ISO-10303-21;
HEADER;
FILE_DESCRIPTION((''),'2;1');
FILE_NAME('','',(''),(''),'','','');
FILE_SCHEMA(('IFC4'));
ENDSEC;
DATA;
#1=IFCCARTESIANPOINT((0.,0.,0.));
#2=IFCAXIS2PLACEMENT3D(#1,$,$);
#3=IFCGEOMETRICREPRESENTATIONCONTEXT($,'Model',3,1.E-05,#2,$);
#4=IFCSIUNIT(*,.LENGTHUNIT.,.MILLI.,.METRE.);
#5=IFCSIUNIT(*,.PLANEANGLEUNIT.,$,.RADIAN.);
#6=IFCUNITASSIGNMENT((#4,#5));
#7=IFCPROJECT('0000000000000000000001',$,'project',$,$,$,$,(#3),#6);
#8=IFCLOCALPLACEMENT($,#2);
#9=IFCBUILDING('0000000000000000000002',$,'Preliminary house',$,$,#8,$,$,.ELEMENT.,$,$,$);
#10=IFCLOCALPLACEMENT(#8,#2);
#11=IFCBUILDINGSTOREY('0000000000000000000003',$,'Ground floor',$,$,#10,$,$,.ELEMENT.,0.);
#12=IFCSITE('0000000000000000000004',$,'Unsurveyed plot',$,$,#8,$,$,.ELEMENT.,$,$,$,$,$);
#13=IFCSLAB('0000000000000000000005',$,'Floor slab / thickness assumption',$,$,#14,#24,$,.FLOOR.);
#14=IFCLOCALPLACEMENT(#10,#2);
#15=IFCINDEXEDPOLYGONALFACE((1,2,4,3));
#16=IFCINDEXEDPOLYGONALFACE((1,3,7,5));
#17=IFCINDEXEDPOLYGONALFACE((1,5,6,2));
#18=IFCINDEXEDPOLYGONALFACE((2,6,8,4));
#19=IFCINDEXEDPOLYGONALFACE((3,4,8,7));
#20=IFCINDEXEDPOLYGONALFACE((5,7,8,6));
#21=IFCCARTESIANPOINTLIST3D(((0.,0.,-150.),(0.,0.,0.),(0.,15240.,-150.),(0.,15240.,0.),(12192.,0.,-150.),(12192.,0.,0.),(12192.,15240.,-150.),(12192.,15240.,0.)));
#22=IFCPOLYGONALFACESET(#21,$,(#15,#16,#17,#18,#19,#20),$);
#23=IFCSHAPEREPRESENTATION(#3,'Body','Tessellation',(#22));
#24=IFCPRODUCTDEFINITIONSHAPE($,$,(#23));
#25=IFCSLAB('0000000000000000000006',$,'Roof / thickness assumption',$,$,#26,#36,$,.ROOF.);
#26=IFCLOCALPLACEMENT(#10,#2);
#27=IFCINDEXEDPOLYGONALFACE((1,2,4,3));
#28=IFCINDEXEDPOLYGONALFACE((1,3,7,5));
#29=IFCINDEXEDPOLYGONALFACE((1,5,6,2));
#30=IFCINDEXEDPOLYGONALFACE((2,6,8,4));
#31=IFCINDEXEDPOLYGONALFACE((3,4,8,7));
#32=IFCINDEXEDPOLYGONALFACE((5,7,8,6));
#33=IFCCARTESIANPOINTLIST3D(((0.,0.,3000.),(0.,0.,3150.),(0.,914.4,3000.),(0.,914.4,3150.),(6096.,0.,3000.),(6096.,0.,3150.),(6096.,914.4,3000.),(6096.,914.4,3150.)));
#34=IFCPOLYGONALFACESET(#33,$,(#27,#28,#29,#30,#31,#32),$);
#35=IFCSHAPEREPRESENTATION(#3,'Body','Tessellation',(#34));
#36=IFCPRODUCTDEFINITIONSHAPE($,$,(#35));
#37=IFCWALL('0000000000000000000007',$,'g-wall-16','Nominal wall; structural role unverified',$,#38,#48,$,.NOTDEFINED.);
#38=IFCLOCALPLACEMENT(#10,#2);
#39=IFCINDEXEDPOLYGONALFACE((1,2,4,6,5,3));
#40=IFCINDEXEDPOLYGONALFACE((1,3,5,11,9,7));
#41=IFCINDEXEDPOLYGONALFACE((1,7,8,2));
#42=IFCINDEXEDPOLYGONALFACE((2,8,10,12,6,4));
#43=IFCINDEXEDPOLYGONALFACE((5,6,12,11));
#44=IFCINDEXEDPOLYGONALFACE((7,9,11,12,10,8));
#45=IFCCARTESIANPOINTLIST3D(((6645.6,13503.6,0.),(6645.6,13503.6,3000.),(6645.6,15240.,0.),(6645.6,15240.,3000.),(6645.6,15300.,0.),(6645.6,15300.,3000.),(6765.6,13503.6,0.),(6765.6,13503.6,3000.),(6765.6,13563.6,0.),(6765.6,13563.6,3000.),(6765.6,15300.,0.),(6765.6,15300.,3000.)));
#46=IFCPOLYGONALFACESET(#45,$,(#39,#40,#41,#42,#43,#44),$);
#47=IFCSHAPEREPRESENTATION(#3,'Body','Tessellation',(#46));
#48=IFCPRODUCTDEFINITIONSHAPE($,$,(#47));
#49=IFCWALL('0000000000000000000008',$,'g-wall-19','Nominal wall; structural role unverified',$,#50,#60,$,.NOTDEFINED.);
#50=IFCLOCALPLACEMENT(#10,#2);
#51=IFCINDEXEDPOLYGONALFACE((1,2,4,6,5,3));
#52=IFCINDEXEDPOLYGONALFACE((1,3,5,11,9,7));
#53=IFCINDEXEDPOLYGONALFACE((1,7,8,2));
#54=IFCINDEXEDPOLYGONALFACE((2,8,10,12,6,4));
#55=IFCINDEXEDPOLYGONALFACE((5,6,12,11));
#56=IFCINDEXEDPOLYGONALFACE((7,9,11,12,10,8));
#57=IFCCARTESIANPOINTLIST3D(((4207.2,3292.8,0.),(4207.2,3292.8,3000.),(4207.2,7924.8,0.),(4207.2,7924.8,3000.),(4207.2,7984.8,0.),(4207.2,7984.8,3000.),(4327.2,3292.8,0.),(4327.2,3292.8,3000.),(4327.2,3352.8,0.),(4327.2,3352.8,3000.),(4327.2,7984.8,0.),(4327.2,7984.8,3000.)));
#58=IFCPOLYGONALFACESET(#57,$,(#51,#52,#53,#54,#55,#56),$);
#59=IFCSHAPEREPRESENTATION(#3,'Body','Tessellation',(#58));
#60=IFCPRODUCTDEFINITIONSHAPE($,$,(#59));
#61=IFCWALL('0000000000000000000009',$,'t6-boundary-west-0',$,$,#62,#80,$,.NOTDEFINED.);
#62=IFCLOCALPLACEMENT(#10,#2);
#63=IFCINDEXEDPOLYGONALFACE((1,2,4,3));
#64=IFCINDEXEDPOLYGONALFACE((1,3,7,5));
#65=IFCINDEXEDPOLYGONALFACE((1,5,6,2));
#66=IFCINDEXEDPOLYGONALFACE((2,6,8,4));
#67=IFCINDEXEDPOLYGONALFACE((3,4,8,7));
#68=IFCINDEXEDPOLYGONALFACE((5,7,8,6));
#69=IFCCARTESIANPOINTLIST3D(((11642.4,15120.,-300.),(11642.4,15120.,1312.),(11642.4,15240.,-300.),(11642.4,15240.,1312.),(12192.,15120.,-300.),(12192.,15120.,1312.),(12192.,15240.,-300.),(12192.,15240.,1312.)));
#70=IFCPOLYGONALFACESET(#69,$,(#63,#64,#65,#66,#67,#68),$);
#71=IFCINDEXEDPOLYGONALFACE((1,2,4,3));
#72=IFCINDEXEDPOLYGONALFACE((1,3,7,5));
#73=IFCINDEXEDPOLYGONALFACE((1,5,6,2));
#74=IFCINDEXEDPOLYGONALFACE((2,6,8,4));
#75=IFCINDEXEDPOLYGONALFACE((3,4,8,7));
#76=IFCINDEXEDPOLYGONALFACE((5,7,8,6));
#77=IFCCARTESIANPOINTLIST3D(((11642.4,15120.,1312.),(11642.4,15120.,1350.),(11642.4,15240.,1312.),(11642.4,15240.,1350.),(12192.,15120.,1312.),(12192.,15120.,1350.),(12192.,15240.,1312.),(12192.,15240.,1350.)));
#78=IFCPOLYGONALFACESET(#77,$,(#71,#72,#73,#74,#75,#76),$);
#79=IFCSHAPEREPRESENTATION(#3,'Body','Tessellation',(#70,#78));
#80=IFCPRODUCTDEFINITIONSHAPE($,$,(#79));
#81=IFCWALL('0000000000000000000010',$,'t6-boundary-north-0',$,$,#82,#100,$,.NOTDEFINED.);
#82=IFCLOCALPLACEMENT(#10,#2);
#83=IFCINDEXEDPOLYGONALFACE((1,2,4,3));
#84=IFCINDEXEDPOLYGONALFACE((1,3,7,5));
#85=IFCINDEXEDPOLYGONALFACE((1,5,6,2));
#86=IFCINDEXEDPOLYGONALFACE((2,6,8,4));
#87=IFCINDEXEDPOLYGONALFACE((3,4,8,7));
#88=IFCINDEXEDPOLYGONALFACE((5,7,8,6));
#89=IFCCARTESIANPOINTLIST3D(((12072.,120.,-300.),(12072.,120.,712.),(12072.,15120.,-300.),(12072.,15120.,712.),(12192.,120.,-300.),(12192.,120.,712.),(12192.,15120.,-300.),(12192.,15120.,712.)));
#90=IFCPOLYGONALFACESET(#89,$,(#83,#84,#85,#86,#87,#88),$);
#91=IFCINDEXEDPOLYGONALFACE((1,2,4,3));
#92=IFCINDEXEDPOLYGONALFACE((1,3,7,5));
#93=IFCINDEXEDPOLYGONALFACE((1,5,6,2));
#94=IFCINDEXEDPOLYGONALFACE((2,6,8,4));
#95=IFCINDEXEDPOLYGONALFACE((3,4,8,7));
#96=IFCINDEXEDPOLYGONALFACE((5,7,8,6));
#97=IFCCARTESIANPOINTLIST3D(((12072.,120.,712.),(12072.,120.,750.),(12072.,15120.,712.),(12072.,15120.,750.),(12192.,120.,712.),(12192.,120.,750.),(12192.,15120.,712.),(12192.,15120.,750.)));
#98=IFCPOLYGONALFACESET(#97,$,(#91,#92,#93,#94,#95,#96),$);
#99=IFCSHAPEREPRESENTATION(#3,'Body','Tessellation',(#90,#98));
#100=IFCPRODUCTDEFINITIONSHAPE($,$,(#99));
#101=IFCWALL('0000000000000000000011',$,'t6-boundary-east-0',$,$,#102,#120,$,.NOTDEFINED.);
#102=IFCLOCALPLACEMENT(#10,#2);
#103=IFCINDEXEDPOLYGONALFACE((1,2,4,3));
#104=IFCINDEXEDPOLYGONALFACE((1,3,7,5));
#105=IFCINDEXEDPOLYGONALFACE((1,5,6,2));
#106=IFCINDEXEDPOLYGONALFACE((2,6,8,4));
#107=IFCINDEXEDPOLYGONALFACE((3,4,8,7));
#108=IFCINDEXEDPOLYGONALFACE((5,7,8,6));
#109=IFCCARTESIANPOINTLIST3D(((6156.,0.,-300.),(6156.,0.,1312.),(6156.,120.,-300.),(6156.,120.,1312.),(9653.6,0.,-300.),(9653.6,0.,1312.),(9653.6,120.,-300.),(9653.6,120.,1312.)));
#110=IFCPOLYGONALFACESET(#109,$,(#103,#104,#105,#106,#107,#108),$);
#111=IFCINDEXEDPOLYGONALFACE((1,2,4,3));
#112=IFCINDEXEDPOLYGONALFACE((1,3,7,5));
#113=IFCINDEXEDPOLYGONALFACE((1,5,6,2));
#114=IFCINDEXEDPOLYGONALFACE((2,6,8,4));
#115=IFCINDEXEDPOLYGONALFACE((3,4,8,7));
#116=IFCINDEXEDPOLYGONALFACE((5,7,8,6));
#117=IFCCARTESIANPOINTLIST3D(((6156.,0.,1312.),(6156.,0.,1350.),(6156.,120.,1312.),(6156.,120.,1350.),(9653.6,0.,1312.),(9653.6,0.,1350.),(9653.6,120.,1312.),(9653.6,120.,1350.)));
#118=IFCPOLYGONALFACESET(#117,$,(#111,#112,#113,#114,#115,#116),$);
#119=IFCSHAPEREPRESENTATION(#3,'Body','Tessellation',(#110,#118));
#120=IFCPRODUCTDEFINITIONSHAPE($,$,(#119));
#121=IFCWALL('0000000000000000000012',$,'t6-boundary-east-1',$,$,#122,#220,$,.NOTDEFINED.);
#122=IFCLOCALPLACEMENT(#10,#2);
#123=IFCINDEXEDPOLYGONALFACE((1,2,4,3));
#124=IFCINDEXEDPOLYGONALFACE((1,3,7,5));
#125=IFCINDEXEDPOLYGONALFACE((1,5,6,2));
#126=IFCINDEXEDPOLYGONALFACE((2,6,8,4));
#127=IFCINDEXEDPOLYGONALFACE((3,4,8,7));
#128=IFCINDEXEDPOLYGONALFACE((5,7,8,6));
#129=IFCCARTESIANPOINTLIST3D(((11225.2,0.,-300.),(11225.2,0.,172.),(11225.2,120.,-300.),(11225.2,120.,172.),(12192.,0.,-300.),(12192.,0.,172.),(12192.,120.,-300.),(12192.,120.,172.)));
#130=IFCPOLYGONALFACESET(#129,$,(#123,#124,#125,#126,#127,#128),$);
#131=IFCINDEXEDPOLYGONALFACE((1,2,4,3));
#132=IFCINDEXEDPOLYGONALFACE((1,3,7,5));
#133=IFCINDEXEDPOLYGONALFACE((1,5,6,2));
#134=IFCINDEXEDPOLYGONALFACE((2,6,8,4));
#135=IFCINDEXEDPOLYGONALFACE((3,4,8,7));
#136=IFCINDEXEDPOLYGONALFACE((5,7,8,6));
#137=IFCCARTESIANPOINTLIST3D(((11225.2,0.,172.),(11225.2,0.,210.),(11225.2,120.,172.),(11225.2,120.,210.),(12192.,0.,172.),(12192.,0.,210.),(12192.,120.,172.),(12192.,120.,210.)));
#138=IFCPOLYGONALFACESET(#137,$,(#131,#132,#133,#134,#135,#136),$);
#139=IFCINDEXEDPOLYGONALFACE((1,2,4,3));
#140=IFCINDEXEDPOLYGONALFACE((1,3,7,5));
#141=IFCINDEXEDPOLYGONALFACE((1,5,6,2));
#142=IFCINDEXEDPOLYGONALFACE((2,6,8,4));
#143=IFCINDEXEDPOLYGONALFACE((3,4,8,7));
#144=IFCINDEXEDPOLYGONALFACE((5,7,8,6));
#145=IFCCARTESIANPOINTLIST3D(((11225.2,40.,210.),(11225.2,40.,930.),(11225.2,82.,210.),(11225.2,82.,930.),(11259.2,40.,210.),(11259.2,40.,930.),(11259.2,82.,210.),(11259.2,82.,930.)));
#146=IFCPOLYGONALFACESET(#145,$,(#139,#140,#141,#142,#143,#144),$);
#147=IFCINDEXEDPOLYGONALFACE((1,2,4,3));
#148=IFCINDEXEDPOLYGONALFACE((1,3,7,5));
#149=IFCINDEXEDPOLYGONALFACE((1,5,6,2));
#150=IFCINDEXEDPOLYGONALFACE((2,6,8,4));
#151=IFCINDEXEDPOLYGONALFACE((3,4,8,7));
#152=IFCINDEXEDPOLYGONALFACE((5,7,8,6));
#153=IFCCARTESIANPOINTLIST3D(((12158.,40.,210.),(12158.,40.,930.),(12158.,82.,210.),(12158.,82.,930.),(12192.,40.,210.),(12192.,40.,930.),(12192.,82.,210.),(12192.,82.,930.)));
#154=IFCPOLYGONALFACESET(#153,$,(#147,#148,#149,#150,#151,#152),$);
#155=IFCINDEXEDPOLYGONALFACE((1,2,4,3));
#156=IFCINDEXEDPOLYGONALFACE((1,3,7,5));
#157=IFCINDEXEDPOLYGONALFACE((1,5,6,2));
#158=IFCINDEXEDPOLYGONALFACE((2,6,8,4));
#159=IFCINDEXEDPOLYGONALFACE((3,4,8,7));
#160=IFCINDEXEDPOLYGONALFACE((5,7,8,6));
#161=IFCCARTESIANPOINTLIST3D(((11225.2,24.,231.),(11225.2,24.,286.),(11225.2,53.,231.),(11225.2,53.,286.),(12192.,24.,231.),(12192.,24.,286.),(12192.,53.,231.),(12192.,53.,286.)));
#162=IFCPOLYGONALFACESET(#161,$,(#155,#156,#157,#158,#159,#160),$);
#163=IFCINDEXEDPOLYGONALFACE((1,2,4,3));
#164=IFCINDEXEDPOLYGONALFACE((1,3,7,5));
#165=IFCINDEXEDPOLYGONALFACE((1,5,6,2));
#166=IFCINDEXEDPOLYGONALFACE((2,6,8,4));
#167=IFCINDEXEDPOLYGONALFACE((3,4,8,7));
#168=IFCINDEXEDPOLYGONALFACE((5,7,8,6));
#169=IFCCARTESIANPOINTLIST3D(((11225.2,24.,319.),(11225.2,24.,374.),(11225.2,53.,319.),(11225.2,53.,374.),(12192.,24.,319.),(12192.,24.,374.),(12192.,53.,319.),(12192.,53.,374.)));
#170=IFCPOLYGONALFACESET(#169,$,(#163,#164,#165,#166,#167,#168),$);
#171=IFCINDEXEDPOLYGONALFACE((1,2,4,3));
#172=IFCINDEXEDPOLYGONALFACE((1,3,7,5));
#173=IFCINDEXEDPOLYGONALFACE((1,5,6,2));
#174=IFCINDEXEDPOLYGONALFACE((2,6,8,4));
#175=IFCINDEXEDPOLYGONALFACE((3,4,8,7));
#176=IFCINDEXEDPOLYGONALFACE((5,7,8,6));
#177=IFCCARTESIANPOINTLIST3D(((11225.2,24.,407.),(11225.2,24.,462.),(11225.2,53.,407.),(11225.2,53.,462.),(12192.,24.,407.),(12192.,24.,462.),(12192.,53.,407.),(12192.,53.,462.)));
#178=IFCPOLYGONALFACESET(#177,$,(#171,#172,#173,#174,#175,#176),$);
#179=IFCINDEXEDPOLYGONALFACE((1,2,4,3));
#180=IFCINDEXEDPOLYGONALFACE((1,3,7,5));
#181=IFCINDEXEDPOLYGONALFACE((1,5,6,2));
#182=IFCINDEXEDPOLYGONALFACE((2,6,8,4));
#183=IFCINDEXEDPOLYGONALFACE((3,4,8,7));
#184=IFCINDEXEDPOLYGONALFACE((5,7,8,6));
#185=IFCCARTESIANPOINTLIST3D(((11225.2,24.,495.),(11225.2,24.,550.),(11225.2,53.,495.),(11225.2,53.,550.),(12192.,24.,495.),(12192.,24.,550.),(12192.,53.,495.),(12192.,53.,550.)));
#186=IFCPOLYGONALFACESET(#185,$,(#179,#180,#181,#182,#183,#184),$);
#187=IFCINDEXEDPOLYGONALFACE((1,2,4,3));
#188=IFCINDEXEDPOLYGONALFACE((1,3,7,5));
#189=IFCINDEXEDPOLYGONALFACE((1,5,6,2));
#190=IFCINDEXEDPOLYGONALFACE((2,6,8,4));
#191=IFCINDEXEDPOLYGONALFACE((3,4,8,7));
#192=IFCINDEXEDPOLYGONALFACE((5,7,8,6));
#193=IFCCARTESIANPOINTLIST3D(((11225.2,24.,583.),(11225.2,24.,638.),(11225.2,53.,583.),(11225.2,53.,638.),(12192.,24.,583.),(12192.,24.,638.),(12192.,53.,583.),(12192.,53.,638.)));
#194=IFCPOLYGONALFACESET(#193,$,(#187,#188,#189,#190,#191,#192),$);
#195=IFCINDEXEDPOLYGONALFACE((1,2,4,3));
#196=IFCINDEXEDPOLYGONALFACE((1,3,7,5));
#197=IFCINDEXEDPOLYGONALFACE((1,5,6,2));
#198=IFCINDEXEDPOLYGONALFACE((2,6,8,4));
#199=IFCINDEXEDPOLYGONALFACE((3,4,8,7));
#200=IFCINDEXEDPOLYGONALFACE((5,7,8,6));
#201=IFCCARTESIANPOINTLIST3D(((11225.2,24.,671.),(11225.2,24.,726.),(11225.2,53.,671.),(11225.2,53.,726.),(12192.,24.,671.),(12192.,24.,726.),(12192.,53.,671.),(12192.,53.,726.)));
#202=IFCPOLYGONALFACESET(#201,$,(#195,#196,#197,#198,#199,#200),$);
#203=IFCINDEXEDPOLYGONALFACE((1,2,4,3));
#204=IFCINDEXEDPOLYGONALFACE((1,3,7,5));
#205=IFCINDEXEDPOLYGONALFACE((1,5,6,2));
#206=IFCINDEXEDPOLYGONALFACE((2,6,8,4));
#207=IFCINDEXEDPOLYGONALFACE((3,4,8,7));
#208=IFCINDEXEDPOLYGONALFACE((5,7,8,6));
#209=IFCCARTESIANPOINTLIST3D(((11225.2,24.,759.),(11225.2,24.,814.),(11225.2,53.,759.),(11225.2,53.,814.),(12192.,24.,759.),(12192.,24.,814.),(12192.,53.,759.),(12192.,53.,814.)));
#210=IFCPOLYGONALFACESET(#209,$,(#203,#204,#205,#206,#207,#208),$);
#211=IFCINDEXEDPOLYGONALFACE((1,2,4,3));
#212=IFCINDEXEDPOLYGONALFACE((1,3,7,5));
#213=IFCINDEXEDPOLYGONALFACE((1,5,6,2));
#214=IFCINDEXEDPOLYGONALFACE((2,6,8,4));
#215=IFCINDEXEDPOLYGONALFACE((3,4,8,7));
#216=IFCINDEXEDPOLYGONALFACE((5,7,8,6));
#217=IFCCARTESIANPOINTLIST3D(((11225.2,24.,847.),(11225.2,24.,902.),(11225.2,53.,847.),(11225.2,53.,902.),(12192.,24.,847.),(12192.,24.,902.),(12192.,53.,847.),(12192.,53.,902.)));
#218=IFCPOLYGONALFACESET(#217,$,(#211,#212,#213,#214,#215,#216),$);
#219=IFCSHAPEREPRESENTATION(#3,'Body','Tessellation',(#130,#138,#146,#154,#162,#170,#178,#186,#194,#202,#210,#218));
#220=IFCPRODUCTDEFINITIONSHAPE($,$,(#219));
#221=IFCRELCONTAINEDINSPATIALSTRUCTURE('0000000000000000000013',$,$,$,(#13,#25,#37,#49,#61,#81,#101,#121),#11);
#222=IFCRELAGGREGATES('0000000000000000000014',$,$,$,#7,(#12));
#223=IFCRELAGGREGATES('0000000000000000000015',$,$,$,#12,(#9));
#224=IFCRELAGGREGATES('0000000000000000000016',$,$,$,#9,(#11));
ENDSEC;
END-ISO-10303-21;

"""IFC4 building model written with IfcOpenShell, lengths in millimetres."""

from ifc_helpers import new_model, si_unit, frame, origin, place, context, project, spatial, polyline, outline, extrude, element, save


model = new_model("IFC4")

# Units and contexts
model_context = context("Model", 3, precision=1e-05, world=origin())
ifc_project = project(units=[si_unit("LENGTHUNIT", "METRE", prefix="MILLI"), si_unit("PLANEANGLEUNIT", "RADIAN")], contexts=[model_context])

# Site, building, storey
placement_1 = place(None, origin())
site = spatial("IfcSite", under=ifc_project, at=placement_1, Name="Unsurveyed plot", CompositionType="ELEMENT")
building = spatial("IfcBuilding", under=site, at=placement_1, Name="Preliminary house", CompositionType="ELEMENT")
placement_2 = place(placement_1, origin())
storey = spatial("IfcBuildingStorey", under=building, at=placement_2, Name="Ground floor", CompositionType="ELEMENT", Elevation=0.0)

# Slabs
element("IfcSlab", 1, at=placement_2, inside=storey, Name="Floor slab / thickness assumption", PredefinedType="FLOOR", context=model_context, shape_type="SweptSolid", body=[
    extrude(outline(polyline([(12192.0, 0.0), (12192.0, 15240.0), (0.0, 15240.0), (0.0, 0.0), (12192.0, 0.0)])), frame((0.0, 0.0, -150.0)), (0.0, 0.0, 1.0), 150.0),
])
element("IfcSlab", 2, at=placement_2, inside=storey, Name="Roof / thickness assumption", PredefinedType="ROOF", context=model_context, shape_type="SweptSolid", body=[
    extrude(outline(polyline([(6096.0, 0.0), (0.0, 0.0), (0.0, 914.4), (6096.0, 914.4), (6096.0, 0.0)])), frame((0.0, 0.0, 3000.0)), (0.0, 0.0, 1.0), 150.0),
])

# Wall
element("IfcWall", 3, at=placement_2, inside=storey, Name="g-wall-16", Description="Nominal wall; structural role unverified", PredefinedType="NOTDEFINED", context=model_context, shape_type="SweptSolid", body=[
    extrude(outline(polyline([(6645.6, 15240.0), (6645.6, 15300.0), (6765.6, 15300.0), (6765.6, 13563.6), (6765.6, 13503.6), (6645.6, 13503.6), (6645.6, 15240.0)])), origin(), (0.0, 0.0, 1.0), 3000.0),
])

# Wall
element("IfcWall", 4, at=placement_2, inside=storey, Name="g-wall-19", Description="Nominal wall; structural role unverified", PredefinedType="NOTDEFINED", context=model_context, shape_type="SweptSolid", body=[
    extrude(outline(polyline([(4207.2, 7924.8), (4207.2, 7984.8), (4327.2, 7984.8), (4327.2, 3352.8), (4327.2, 3292.8), (4207.2, 3292.8), (4207.2, 7924.8)])), origin(), (0.0, 0.0, 1.0), 3000.0),
])

# Walls
element("IfcWall", 5, at=placement_2, inside=storey, Name="t6-boundary-west-0", PredefinedType="NOTDEFINED", context=model_context, shape_type="SweptSolid", body=[
    extrude(outline(polyline([(12192.0, 15120.0), (12192.0, 15240.0), (11642.4, 15240.0), (11642.4, 15120.0), (12192.0, 15120.0)])), frame((0.0, 0.0, -300.0)), (0.0, 0.0, 1.0), 1612.0),
    extrude(outline(polyline([(12192.0, 15120.0), (12192.0, 15240.0), (11642.4, 15240.0), (11642.4, 15120.0), (12192.0, 15120.0)])), frame((0.0, 0.0, 1312.0)), (0.0, 0.0, 1.0), 38.0),
])
element("IfcWall", 6, at=placement_2, inside=storey, Name="t6-boundary-north-0", PredefinedType="NOTDEFINED", context=model_context, shape_type="SweptSolid", body=[
    extrude(outline(polyline([(12192.0, 120.0), (12192.0, 15120.0), (12072.0, 15120.0), (12072.0, 120.0), (12192.0, 120.0)])), frame((0.0, 0.0, -300.0)), (0.0, 0.0, 1.0), 1012.0),
    extrude(outline(polyline([(12192.0, 120.0), (12192.0, 15120.0), (12072.0, 15120.0), (12072.0, 120.0), (12192.0, 120.0)])), frame((0.0, 0.0, 712.0)), (0.0, 0.0, 1.0), 38.0),
])
element("IfcWall", 7, at=placement_2, inside=storey, Name="t6-boundary-east-0", PredefinedType="NOTDEFINED", context=model_context, shape_type="SweptSolid", body=[
    extrude(outline(polyline([(9653.6, 0.0), (9653.6, 120.0), (6156.0, 120.0), (6156.0, 0.0), (9653.6, 0.0)])), frame((0.0, 0.0, -300.0)), (0.0, 0.0, 1.0), 1612.0),
    extrude(outline(polyline([(9653.6, 0.0), (9653.6, 120.0), (6156.0, 120.0), (6156.0, 0.0), (9653.6, 0.0)])), frame((0.0, 0.0, 1312.0)), (0.0, 0.0, 1.0), 38.0),
])
element("IfcWall", 8, at=placement_2, inside=storey, Name="t6-boundary-east-1", PredefinedType="NOTDEFINED", context=model_context, shape_type="SweptSolid", body=[
    extrude(outline(polyline([(12192.0, 0.0), (12192.0, 120.0), (11225.2, 120.0), (11225.2, 0.0), (12192.0, 0.0)])), frame((0.0, 0.0, -300.0)), (0.0, 0.0, 1.0), 472.0),
    extrude(outline(polyline([(12192.0, 0.0), (12192.0, 120.0), (11225.2, 120.0), (11225.2, 0.0), (12192.0, 0.0)])), frame((0.0, 0.0, 172.0)), (0.0, 0.0, 1.0), 38.0),
    extrude(outline(polyline([(11259.2, 40.0), (11259.2, 82.0), (11225.2, 82.0), (11225.2, 40.0), (11259.2, 40.0)])), frame((0.0, 0.0, 210.0)), (0.0, 0.0, 1.0), 720.0),
    extrude(outline(polyline([(12192.0, 40.0), (12192.0, 82.0), (12158.0, 82.0), (12158.0, 40.0), (12192.0, 40.0)])), frame((0.0, 0.0, 210.0)), (0.0, 0.0, 1.0), 720.0),
    extrude(outline(polyline([(12192.0, 24.0), (12192.0, 53.0), (11225.2, 53.0), (11225.2, 24.0), (12192.0, 24.0)])), frame((0.0, 0.0, 231.0)), (0.0, 0.0, 1.0), 55.0),
    extrude(outline(polyline([(12192.0, 24.0), (12192.0, 53.0), (11225.2, 53.0), (11225.2, 24.0), (12192.0, 24.0)])), frame((0.0, 0.0, 319.0)), (0.0, 0.0, 1.0), 55.0),
    extrude(outline(polyline([(12192.0, 24.0), (12192.0, 53.0), (11225.2, 53.0), (11225.2, 24.0), (12192.0, 24.0)])), frame((0.0, 0.0, 407.0)), (0.0, 0.0, 1.0), 55.0),
    extrude(outline(polyline([(12192.0, 24.0), (12192.0, 53.0), (11225.2, 53.0), (11225.2, 24.0), (12192.0, 24.0)])), frame((0.0, 0.0, 495.0)), (0.0, 0.0, 1.0), 55.0),
    extrude(outline(polyline([(12192.0, 24.0), (12192.0, 53.0), (11225.2, 53.0), (11225.2, 24.0), (12192.0, 24.0)])), frame((0.0, 0.0, 583.0)), (0.0, 0.0, 1.0), 55.0),
    extrude(outline(polyline([(12192.0, 24.0), (12192.0, 53.0), (11225.2, 53.0), (11225.2, 24.0), (12192.0, 24.0)])), frame((0.0, 0.0, 671.0)), (0.0, 0.0, 1.0), 55.0),
    extrude(outline(polyline([(12192.0, 24.0), (12192.0, 53.0), (11225.2, 53.0), (11225.2, 24.0), (12192.0, 24.0)])), frame((0.0, 0.0, 759.0)), (0.0, 0.0, 1.0), 55.0),
    extrude(outline(polyline([(12192.0, 24.0), (12192.0, 53.0), (11225.2, 53.0), (11225.2, 24.0), (12192.0, 24.0)])), frame((0.0, 0.0, 847.0)), (0.0, 0.0, 1.0), 55.0),
])

save(model, "model.ifc")
